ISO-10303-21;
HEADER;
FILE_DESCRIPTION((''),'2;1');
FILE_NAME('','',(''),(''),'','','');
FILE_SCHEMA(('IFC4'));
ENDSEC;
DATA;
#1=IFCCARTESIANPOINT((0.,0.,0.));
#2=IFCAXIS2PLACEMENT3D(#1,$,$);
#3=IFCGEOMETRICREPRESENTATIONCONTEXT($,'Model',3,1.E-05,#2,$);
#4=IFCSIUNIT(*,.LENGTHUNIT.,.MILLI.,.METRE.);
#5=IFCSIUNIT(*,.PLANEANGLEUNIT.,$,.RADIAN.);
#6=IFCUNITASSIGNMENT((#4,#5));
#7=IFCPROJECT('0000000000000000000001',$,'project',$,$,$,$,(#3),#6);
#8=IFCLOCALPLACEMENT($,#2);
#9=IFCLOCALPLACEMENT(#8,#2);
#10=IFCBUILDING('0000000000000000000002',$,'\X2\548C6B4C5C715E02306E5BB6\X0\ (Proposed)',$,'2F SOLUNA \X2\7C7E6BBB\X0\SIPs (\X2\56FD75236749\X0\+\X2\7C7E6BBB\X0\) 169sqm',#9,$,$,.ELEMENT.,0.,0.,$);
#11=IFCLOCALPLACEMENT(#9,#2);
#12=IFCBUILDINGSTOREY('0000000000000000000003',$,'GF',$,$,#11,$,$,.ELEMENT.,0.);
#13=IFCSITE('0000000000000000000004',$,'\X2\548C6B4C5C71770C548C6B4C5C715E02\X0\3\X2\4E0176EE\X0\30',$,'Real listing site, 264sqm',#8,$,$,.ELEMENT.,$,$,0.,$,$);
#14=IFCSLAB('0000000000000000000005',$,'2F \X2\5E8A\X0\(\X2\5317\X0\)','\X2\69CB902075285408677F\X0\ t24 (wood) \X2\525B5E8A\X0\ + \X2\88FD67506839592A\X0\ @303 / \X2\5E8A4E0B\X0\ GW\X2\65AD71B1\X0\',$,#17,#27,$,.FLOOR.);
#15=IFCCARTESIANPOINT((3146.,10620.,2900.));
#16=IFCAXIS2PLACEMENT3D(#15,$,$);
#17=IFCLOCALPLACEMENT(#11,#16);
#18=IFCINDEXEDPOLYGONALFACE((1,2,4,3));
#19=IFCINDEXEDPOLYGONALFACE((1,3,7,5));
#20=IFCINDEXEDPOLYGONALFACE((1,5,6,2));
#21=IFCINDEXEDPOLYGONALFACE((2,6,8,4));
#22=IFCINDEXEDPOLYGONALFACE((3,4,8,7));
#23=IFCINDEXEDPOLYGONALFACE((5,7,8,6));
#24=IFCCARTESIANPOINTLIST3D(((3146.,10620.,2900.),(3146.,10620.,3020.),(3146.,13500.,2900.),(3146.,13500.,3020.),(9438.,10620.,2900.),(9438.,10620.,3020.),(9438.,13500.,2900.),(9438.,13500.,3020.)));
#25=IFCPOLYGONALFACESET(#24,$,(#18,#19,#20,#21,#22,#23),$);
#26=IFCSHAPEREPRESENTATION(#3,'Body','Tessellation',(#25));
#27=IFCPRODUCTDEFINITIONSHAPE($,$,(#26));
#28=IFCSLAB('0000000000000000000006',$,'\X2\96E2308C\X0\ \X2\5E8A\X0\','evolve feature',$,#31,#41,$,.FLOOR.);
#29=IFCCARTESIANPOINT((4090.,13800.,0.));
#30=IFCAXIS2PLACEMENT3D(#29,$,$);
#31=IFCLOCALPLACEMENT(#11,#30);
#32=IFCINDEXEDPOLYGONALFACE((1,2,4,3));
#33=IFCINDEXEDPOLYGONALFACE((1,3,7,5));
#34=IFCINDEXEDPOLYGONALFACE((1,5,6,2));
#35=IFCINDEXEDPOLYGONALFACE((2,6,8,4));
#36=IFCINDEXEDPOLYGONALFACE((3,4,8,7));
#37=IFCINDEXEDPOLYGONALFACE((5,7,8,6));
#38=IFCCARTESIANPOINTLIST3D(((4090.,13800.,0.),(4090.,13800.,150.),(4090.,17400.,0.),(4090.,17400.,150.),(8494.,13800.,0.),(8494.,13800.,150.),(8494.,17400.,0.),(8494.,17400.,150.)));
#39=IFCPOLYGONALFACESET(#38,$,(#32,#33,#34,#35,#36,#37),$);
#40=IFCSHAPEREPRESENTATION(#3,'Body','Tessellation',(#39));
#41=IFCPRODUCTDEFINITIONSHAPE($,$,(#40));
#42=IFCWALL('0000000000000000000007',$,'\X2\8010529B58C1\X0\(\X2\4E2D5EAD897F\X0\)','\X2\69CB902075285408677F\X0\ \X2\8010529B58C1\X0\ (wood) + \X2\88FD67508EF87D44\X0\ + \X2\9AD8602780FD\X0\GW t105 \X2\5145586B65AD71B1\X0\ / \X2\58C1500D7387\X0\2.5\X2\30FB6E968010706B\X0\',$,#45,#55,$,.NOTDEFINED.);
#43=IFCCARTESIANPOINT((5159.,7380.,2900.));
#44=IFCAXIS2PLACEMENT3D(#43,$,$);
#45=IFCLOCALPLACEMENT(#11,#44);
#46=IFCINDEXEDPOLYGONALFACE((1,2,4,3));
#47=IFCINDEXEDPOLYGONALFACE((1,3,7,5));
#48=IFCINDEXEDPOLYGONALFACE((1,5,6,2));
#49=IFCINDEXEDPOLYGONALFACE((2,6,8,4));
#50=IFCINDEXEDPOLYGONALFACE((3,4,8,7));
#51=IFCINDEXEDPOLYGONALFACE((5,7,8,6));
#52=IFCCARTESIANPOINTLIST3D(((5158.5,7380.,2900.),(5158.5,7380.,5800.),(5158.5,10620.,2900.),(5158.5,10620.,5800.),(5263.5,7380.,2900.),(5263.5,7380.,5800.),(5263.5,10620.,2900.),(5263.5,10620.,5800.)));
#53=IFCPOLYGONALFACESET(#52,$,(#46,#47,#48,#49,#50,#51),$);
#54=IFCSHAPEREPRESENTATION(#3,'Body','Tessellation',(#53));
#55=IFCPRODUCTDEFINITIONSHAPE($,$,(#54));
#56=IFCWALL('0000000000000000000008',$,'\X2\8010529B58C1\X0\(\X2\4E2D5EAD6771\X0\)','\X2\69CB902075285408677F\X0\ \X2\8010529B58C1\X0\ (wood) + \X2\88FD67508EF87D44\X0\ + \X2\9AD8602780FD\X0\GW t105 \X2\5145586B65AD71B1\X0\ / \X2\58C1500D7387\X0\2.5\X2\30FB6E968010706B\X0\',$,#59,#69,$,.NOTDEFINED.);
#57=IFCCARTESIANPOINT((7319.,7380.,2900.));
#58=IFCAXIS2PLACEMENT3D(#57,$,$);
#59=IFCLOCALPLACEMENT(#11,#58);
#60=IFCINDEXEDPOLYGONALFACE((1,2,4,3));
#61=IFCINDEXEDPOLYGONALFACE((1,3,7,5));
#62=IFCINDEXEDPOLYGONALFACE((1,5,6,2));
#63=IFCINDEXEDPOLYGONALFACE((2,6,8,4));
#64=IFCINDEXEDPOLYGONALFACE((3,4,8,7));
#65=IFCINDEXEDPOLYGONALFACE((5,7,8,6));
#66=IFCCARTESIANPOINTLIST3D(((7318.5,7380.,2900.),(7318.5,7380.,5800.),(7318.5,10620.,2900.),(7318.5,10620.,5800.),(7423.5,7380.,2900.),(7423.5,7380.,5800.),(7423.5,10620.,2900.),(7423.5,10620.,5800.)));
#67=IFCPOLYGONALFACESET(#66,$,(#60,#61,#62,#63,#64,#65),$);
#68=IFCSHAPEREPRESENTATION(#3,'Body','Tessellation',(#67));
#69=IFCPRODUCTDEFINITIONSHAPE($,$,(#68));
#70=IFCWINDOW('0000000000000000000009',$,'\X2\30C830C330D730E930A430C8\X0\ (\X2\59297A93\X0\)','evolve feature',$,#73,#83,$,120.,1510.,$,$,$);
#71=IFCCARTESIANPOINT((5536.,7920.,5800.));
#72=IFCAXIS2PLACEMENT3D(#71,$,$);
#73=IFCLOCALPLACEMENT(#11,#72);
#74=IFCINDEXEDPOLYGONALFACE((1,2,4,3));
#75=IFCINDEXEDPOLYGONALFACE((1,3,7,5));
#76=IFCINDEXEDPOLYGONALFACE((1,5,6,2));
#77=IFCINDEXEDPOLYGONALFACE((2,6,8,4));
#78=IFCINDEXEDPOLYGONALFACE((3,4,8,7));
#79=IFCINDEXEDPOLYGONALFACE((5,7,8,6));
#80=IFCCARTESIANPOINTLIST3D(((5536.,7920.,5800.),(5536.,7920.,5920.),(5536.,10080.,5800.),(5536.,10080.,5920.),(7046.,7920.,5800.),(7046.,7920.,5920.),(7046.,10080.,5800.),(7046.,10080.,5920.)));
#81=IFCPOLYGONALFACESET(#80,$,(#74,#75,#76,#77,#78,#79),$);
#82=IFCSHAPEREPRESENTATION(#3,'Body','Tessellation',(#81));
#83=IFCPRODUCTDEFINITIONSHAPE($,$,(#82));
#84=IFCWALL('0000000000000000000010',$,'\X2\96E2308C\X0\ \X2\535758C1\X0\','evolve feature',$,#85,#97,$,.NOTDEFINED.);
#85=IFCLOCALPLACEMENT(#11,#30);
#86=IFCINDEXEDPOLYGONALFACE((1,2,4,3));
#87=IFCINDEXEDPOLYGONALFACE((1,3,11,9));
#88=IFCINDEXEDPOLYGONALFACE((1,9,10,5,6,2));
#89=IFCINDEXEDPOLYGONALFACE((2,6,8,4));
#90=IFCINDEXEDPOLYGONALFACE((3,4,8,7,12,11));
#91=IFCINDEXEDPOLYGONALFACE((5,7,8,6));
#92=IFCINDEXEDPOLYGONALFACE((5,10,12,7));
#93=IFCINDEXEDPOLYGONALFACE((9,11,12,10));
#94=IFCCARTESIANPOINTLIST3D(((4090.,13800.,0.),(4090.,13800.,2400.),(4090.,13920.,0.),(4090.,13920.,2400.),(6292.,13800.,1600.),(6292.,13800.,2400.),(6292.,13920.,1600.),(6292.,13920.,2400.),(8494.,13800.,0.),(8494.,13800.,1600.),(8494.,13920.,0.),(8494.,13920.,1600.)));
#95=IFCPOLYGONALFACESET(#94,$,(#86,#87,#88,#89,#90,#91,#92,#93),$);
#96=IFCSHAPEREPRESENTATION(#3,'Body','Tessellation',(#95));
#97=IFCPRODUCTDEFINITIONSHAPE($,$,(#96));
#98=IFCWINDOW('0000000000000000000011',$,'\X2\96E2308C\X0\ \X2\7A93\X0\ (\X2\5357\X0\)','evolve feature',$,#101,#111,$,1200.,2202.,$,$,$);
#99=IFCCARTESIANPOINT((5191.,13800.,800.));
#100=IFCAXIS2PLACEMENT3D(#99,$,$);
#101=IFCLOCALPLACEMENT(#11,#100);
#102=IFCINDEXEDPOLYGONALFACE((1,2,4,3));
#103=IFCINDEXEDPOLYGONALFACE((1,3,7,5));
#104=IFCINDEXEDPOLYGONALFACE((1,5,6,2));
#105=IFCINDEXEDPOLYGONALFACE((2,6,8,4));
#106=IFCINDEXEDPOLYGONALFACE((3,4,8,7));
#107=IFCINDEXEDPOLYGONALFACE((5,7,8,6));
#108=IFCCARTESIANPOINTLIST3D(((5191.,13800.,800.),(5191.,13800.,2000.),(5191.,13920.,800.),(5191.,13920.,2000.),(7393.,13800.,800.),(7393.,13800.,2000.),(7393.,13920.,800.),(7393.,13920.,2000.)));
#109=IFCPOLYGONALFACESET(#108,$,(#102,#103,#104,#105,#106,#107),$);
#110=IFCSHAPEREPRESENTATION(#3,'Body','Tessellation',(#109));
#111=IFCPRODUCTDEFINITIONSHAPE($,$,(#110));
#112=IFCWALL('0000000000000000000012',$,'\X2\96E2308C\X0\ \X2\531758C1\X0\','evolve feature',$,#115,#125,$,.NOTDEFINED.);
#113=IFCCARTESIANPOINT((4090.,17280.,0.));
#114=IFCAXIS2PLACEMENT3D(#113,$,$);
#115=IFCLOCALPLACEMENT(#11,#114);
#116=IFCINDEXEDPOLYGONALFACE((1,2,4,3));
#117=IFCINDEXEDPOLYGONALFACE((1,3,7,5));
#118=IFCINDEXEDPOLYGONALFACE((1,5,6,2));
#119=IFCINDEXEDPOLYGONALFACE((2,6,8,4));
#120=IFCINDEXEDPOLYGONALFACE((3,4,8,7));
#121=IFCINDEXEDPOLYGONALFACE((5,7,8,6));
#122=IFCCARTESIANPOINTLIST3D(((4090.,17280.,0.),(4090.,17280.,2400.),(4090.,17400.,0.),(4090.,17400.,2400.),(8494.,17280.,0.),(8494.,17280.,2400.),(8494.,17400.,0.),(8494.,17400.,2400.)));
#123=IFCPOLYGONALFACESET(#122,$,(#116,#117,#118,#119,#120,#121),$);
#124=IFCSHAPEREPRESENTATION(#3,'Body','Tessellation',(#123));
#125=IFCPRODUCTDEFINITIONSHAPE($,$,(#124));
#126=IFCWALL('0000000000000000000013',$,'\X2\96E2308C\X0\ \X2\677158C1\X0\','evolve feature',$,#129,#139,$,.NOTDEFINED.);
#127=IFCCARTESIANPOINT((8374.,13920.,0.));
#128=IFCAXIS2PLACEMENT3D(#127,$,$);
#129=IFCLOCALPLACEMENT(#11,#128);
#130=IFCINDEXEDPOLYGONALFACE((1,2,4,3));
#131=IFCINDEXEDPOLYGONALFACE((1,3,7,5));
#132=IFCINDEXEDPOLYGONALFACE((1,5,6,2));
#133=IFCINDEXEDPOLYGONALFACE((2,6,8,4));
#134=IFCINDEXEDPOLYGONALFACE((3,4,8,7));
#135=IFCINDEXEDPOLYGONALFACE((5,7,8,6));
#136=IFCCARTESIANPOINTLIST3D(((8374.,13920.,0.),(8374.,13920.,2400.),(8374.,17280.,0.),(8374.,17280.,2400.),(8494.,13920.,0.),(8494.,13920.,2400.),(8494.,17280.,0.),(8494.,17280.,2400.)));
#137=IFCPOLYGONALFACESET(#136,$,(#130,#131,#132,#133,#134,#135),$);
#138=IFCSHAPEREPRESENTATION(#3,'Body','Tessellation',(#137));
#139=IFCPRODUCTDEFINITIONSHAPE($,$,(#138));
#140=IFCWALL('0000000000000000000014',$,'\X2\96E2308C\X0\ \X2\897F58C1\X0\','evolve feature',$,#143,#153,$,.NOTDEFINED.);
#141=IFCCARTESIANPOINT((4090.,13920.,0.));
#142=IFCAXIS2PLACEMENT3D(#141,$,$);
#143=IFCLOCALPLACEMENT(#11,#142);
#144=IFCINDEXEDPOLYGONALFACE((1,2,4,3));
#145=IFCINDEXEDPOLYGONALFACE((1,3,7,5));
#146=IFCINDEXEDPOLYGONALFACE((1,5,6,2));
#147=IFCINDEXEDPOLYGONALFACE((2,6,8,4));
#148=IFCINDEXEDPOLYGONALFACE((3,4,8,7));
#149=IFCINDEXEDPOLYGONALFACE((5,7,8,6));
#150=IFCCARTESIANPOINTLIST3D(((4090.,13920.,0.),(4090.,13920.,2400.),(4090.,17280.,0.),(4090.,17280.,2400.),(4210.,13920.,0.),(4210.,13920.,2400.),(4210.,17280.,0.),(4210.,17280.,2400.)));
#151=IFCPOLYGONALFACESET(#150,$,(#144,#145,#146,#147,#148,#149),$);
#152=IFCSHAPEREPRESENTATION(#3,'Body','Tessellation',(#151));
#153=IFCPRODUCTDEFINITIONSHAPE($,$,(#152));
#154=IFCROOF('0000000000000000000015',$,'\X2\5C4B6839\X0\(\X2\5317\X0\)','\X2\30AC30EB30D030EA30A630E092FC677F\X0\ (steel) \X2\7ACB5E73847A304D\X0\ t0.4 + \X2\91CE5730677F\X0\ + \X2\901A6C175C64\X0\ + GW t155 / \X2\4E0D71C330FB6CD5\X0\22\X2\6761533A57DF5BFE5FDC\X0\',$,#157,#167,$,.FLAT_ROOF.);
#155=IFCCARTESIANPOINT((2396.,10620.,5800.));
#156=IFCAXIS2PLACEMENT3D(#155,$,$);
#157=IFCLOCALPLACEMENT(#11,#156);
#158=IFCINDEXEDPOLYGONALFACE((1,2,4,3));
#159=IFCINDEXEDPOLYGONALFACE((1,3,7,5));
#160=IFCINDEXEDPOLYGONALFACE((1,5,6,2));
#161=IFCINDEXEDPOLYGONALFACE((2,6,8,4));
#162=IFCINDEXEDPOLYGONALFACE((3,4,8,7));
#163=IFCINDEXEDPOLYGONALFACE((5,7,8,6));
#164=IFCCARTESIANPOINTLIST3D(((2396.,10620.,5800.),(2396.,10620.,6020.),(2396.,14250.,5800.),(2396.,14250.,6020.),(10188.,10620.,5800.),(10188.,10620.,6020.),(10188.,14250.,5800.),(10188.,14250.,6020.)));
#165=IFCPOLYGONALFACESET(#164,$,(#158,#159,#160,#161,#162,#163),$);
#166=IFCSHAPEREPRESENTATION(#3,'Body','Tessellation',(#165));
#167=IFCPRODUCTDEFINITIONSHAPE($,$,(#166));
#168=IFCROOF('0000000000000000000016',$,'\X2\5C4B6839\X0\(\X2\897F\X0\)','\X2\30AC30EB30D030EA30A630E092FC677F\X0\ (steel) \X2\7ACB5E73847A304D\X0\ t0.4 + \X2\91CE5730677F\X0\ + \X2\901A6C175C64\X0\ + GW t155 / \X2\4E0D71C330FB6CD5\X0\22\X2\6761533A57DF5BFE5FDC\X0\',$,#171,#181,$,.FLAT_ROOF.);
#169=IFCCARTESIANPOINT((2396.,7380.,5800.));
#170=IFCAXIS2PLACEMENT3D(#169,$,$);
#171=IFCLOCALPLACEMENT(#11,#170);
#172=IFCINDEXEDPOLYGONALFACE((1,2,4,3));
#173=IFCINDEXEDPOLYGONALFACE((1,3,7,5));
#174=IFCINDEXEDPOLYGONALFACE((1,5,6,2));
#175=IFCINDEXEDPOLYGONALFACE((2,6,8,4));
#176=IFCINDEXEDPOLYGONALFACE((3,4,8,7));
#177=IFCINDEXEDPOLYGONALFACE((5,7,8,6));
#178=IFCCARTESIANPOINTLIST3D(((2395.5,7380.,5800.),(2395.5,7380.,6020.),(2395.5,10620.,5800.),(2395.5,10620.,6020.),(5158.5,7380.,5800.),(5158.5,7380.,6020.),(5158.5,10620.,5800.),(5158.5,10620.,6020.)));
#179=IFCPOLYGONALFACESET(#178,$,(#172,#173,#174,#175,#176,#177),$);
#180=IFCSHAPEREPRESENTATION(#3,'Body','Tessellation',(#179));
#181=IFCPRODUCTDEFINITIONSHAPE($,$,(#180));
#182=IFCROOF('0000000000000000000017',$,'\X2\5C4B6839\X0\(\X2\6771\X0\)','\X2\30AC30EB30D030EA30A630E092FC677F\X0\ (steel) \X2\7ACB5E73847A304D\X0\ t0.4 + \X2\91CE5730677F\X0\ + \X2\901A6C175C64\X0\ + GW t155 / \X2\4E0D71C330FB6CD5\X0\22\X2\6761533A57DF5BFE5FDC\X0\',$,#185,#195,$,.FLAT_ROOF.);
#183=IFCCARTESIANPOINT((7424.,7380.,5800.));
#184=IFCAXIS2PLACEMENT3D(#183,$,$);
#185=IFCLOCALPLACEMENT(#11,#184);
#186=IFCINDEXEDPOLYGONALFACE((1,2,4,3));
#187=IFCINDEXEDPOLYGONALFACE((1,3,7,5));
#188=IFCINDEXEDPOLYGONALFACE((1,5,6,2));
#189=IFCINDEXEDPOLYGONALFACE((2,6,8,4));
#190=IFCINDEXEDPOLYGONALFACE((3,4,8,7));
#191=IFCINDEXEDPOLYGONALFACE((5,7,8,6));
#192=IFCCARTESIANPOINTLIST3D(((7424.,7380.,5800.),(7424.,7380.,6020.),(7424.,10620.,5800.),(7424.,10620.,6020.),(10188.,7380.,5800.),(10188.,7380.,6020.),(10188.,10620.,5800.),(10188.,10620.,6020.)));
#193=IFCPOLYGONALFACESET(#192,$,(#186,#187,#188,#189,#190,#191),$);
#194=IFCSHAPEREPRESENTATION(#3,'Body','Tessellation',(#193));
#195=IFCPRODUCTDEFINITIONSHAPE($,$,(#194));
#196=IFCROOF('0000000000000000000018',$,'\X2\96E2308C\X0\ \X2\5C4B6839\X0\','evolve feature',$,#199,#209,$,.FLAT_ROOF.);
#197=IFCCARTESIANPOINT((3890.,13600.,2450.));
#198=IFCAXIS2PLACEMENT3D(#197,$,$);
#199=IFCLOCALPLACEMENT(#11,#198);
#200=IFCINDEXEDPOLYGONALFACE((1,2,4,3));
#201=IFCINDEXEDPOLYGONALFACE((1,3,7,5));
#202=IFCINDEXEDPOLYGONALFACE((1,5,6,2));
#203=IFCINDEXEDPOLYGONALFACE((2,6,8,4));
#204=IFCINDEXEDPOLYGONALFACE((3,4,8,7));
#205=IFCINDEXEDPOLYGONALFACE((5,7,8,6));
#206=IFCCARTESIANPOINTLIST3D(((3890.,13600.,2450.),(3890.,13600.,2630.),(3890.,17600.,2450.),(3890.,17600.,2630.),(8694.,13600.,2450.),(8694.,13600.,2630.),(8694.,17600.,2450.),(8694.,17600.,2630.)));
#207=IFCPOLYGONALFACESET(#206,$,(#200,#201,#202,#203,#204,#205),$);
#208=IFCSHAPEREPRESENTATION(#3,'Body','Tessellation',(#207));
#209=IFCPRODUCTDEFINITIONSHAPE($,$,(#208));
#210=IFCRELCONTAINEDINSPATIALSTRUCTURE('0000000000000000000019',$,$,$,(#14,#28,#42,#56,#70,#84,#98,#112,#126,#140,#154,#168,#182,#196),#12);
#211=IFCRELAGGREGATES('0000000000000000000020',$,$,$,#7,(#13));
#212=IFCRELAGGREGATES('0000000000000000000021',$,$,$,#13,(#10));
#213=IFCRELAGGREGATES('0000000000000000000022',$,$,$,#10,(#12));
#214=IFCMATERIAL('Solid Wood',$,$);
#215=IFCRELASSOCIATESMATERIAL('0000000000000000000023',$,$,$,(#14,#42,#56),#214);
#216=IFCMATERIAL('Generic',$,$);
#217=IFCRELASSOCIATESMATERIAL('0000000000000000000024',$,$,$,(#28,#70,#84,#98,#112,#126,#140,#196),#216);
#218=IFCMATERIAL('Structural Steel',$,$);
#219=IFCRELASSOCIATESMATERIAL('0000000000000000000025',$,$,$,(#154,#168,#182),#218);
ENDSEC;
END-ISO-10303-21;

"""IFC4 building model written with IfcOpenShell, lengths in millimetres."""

from ifc_helpers import new_model, si_unit, frame, frame_2d, origin, place, context, project, spatial, rectangle, extrude, material, element, fill, save


model = new_model("IFC4")

# Units and contexts
model_context = context("Model", 3, precision=1e-05, world=origin())
ifc_project = project(units=[si_unit("LENGTHUNIT", "METRE", prefix="MILLI"), si_unit("PLANEANGLEUNIT", "RADIAN")], contexts=[model_context])

# Site, building, storey
site_placement = place(None, origin())
site = spatial("IfcSite", under=ifc_project, at=site_placement, Name="和歌山県和歌山市3丁目30", ObjectType="Real listing site, 264sqm", CompositionType="ELEMENT", RefElevation=0.0)
building_placement = place(site_placement, origin())
building = spatial("IfcBuilding", under=site, at=building_placement, Name="和歌山市の家 (Proposed)", ObjectType="2F SOLUNA 籾殻SIPs (国産杉+籾殻) 169sqm", CompositionType="ELEMENT", ElevationOfRefHeight=0.0, ElevationOfTerrain=0.0)
storey_placement = place(building_placement, origin())
storey = spatial("IfcBuildingStorey", under=building, at=storey_placement, Name="GF", CompositionType="ELEMENT", Elevation=0.0)

# Slabs
ifc_material_1 = material(Name="Solid Wood")
slab_1_placement = place(storey_placement, frame((3146.0, 10620.0, 2900.0)))
element("IfcSlab", 1, at=slab_1_placement, inside=storey, material=ifc_material_1, Name="2F 床(北)", Description="構造用合板 t24 (wood) 剛床 + 製材根太 @303 / 床下 GW断熱", PredefinedType="FLOOR", context=model_context, shape_type="SweptSolid", body=[
    extrude(rectangle(XDim=6292.0, YDim=2880.0, at=frame_2d((3146.0, 1440.0))), frame((3146.0, 10620.0, 2900.0)), (0.0, 0.0, 1.0), 120.0),
])
ifc_material_2 = material(Name="Generic")
slab_2_placement = place(storey_placement, frame((4090.0, 13800.0, 0.0)))
element("IfcSlab", 2, at=slab_2_placement, inside=storey, material=ifc_material_2, Name="離れ 床", Description="evolve feature", PredefinedType="FLOOR", context=model_context, shape_type="SweptSolid", body=[
    extrude(rectangle(XDim=4404.0, YDim=3600.0, at=frame_2d((2202.0, 1800.0))), frame((4090.0, 13800.0, 0.0)), (0.0, 0.0, 1.0), 150.0),
])

# Walls
wall_1_placement = place(storey_placement, frame((5159.0, 7380.0, 2900.0)))
element("IfcWall", 3, at=wall_1_placement, inside=storey, material=ifc_material_1, Name="耐力壁(中庭西)", Description="構造用合板 耐力壁 (wood) + 製材軸組 + 高性能GW t105 充填断熱 / 壁倍率2.5・準耐火", PredefinedType="NOTDEFINED", context=model_context, shape_type="SweptSolid", body=[
    extrude(rectangle(XDim=105.0, YDim=3240.0, at=frame_2d((52.0, 1620.0))), frame((5159.0, 7380.0, 2900.0)), (0.0, 0.0, 1.0), 2900.0),
])
wall_2_placement = place(storey_placement, frame((7319.0, 7380.0, 2900.0)))
element("IfcWall", 4, at=wall_2_placement, inside=storey, material=ifc_material_1, Name="耐力壁(中庭東)", Description="構造用合板 耐力壁 (wood) + 製材軸組 + 高性能GW t105 充填断熱 / 壁倍率2.5・準耐火", PredefinedType="NOTDEFINED", context=model_context, shape_type="SweptSolid", body=[
    extrude(rectangle(XDim=105.0, YDim=3240.0, at=frame_2d((52.0, 1620.0))), frame((7319.0, 7380.0, 2900.0)), (0.0, 0.0, 1.0), 2900.0),
])

# Window
window_1_placement = place(storey_placement, frame((5536.0, 7920.0, 5800.0)))
element("IfcWindow", 5, at=window_1_placement, inside=storey, material=ifc_material_2, Name="トップライト (天窓)", Description="evolve feature", OverallHeight=120.0, OverallWidth=1510.0, context=model_context, shape_type="SweptSolid", body=[
    extrude(rectangle(XDim=1510.0, YDim=2160.0, at=frame_2d((755.0, 1080.0))), frame((5536.0, 7920.0, 5800.0)), (0.0, 0.0, 1.0), 120.0),
])

# Wall, opening, window
wall_3_placement = place(storey_placement, frame((4090.0, 13800.0, 0.0)))
wall_3 = element("IfcWall", 6, at=wall_3_placement, inside=storey, material=ifc_material_2, Name="離れ 南壁", Description="evolve feature", PredefinedType="NOTDEFINED", context=model_context, shape_type="SweptSolid", body=[
    extrude(rectangle(XDim=4404.0, YDim=120.0, at=frame_2d((2202.0, 60.0))), frame((4090.0, 13800.0, 0.0)), (0.0, 0.0, 1.0), 2400.0),
])
opening_1_placement = place(storey_placement, frame((5191.0, 13800.0, 800.0)))
opening_1 = element("IfcOpeningElement", 7, at=opening_1_placement, cuts=wall_3, PredefinedType="NOTDEFINED", context=model_context, shape_type="SweptSolid", body=[
    extrude(rectangle(XDim=2202.0, YDim=120.0, at=frame_2d((1101.0, 60.0))), frame((5191.0, 13800.0, 800.0)), (0.0, 0.0, 1.0), 1200.0),
])
window_2_placement = place(storey_placement, frame((5191.0, 13800.0, 800.0)))
window_2 = element("IfcWindow", 8, at=window_2_placement, inside=storey, material=ifc_material_2, Name="離れ 窓 (南)", Description="evolve feature", OverallHeight=1200.0, OverallWidth=2202.0, context=model_context, shape_type="SweptSolid", body=[
    extrude(rectangle(XDim=2202.0, YDim=120.0, at=frame_2d((1101.0, 60.0))), frame((5191.0, 13800.0, 800.0)), (0.0, 0.0, 1.0), 1200.0),
])
fill(opening_1, window_2)

# Walls
wall_4_placement = place(storey_placement, frame((4090.0, 17280.0, 0.0)))
element("IfcWall", 9, at=wall_4_placement, inside=storey, material=ifc_material_2, Name="離れ 北壁", Description="evolve feature", PredefinedType="NOTDEFINED", context=model_context, shape_type="SweptSolid", body=[
    extrude(rectangle(XDim=4404.0, YDim=120.0, at=frame_2d((2202.0, 60.0))), frame((4090.0, 17280.0, 0.0)), (0.0, 0.0, 1.0), 2400.0),
])
wall_5_placement = place(storey_placement, frame((8374.0, 13920.0, 0.0)))
element("IfcWall", 10, at=wall_5_placement, inside=storey, material=ifc_material_2, Name="離れ 東壁", Description="evolve feature", PredefinedType="NOTDEFINED", context=model_context, shape_type="SweptSolid", body=[
    extrude(rectangle(XDim=120.0, YDim=3360.0, at=frame_2d((60.0, 1680.0))), frame((8374.0, 13920.0, 0.0)), (0.0, 0.0, 1.0), 2400.0),
])
wall_6_placement = place(storey_placement, frame((4090.0, 13920.0, 0.0)))
element("IfcWall", 11, at=wall_6_placement, inside=storey, material=ifc_material_2, Name="離れ 西壁", Description="evolve feature", PredefinedType="NOTDEFINED", context=model_context, shape_type="SweptSolid", body=[
    extrude(rectangle(XDim=120.0, YDim=3360.0, at=frame_2d((60.0, 1680.0))), frame((4090.0, 13920.0, 0.0)), (0.0, 0.0, 1.0), 2400.0),
])

# Roofs
ifc_material_3 = material(Name="Structural Steel")
for number, where, name in (
    (12, (2396.0, 10620.0, 5800.0), "屋根(北)"),
):
    element("IfcRoof", number, at=place(storey_placement, frame(where)), inside=storey, material=ifc_material_3, Name=name, Description="ガルバリウム鋼板 (steel) 立平葺き t0.4 + 野地板 + 通気層 + GW t155 / 不燃・法22条区域対応", PredefinedType="FLAT_ROOF", context=model_context, shape_type="SweptSolid", body=[
        extrude(rectangle(XDim=7792.0, YDim=3630.0, at=frame_2d((3896.0, 1815.0))), frame((2396.0, 10620.0, 5800.0)), (0.0, 0.0, 1.0), 220.0),
    ])
roof_1_placement = place(storey_placement, frame((2396.0, 7380.0, 5800.0)))
element("IfcRoof", 13, at=roof_1_placement, inside=storey, material=ifc_material_3, Name="屋根(西)", Description="ガルバリウム鋼板 (steel) 立平葺き t0.4 + 野地板 + 通気層 + GW t155 / 不燃・法22条区域対応", PredefinedType="FLAT_ROOF", context=model_context, shape_type="SweptSolid", body=[
    extrude(rectangle(XDim=2763.0, YDim=3240.0, at=frame_2d((1381.0, 1620.0))), frame((2396.0, 7380.0, 5800.0)), (0.0, 0.0, 1.0), 220.0),
])
roof_2_placement = place(storey_placement, frame((7424.0, 7380.0, 5800.0)))
element("IfcRoof", 14, at=roof_2_placement, inside=storey, material=ifc_material_3, Name="屋根(東)", Description="ガルバリウム鋼板 (steel) 立平葺き t0.4 + 野地板 + 通気層 + GW t155 / 不燃・法22条区域対応", PredefinedType="FLAT_ROOF", context=model_context, shape_type="SweptSolid", body=[
    extrude(rectangle(XDim=2764.0, YDim=3240.0, at=frame_2d((1382.0, 1620.0))), frame((7424.0, 7380.0, 5800.0)), (0.0, 0.0, 1.0), 220.0),
])
roof_3_placement = place(storey_placement, frame((3890.0, 13600.0, 2450.0)))
element("IfcRoof", 15, at=roof_3_placement, inside=storey, material=ifc_material_2, Name="離れ 屋根", Description="evolve feature", PredefinedType="FLAT_ROOF", context=model_context, shape_type="SweptSolid", body=[
    extrude(rectangle(XDim=4804.0, YDim=4000.0, at=frame_2d((2402.0, 2000.0))), frame((3890.0, 13600.0, 2450.0)), (0.0, 0.0, 1.0), 180.0),
])

save(model, "model.ifc")
